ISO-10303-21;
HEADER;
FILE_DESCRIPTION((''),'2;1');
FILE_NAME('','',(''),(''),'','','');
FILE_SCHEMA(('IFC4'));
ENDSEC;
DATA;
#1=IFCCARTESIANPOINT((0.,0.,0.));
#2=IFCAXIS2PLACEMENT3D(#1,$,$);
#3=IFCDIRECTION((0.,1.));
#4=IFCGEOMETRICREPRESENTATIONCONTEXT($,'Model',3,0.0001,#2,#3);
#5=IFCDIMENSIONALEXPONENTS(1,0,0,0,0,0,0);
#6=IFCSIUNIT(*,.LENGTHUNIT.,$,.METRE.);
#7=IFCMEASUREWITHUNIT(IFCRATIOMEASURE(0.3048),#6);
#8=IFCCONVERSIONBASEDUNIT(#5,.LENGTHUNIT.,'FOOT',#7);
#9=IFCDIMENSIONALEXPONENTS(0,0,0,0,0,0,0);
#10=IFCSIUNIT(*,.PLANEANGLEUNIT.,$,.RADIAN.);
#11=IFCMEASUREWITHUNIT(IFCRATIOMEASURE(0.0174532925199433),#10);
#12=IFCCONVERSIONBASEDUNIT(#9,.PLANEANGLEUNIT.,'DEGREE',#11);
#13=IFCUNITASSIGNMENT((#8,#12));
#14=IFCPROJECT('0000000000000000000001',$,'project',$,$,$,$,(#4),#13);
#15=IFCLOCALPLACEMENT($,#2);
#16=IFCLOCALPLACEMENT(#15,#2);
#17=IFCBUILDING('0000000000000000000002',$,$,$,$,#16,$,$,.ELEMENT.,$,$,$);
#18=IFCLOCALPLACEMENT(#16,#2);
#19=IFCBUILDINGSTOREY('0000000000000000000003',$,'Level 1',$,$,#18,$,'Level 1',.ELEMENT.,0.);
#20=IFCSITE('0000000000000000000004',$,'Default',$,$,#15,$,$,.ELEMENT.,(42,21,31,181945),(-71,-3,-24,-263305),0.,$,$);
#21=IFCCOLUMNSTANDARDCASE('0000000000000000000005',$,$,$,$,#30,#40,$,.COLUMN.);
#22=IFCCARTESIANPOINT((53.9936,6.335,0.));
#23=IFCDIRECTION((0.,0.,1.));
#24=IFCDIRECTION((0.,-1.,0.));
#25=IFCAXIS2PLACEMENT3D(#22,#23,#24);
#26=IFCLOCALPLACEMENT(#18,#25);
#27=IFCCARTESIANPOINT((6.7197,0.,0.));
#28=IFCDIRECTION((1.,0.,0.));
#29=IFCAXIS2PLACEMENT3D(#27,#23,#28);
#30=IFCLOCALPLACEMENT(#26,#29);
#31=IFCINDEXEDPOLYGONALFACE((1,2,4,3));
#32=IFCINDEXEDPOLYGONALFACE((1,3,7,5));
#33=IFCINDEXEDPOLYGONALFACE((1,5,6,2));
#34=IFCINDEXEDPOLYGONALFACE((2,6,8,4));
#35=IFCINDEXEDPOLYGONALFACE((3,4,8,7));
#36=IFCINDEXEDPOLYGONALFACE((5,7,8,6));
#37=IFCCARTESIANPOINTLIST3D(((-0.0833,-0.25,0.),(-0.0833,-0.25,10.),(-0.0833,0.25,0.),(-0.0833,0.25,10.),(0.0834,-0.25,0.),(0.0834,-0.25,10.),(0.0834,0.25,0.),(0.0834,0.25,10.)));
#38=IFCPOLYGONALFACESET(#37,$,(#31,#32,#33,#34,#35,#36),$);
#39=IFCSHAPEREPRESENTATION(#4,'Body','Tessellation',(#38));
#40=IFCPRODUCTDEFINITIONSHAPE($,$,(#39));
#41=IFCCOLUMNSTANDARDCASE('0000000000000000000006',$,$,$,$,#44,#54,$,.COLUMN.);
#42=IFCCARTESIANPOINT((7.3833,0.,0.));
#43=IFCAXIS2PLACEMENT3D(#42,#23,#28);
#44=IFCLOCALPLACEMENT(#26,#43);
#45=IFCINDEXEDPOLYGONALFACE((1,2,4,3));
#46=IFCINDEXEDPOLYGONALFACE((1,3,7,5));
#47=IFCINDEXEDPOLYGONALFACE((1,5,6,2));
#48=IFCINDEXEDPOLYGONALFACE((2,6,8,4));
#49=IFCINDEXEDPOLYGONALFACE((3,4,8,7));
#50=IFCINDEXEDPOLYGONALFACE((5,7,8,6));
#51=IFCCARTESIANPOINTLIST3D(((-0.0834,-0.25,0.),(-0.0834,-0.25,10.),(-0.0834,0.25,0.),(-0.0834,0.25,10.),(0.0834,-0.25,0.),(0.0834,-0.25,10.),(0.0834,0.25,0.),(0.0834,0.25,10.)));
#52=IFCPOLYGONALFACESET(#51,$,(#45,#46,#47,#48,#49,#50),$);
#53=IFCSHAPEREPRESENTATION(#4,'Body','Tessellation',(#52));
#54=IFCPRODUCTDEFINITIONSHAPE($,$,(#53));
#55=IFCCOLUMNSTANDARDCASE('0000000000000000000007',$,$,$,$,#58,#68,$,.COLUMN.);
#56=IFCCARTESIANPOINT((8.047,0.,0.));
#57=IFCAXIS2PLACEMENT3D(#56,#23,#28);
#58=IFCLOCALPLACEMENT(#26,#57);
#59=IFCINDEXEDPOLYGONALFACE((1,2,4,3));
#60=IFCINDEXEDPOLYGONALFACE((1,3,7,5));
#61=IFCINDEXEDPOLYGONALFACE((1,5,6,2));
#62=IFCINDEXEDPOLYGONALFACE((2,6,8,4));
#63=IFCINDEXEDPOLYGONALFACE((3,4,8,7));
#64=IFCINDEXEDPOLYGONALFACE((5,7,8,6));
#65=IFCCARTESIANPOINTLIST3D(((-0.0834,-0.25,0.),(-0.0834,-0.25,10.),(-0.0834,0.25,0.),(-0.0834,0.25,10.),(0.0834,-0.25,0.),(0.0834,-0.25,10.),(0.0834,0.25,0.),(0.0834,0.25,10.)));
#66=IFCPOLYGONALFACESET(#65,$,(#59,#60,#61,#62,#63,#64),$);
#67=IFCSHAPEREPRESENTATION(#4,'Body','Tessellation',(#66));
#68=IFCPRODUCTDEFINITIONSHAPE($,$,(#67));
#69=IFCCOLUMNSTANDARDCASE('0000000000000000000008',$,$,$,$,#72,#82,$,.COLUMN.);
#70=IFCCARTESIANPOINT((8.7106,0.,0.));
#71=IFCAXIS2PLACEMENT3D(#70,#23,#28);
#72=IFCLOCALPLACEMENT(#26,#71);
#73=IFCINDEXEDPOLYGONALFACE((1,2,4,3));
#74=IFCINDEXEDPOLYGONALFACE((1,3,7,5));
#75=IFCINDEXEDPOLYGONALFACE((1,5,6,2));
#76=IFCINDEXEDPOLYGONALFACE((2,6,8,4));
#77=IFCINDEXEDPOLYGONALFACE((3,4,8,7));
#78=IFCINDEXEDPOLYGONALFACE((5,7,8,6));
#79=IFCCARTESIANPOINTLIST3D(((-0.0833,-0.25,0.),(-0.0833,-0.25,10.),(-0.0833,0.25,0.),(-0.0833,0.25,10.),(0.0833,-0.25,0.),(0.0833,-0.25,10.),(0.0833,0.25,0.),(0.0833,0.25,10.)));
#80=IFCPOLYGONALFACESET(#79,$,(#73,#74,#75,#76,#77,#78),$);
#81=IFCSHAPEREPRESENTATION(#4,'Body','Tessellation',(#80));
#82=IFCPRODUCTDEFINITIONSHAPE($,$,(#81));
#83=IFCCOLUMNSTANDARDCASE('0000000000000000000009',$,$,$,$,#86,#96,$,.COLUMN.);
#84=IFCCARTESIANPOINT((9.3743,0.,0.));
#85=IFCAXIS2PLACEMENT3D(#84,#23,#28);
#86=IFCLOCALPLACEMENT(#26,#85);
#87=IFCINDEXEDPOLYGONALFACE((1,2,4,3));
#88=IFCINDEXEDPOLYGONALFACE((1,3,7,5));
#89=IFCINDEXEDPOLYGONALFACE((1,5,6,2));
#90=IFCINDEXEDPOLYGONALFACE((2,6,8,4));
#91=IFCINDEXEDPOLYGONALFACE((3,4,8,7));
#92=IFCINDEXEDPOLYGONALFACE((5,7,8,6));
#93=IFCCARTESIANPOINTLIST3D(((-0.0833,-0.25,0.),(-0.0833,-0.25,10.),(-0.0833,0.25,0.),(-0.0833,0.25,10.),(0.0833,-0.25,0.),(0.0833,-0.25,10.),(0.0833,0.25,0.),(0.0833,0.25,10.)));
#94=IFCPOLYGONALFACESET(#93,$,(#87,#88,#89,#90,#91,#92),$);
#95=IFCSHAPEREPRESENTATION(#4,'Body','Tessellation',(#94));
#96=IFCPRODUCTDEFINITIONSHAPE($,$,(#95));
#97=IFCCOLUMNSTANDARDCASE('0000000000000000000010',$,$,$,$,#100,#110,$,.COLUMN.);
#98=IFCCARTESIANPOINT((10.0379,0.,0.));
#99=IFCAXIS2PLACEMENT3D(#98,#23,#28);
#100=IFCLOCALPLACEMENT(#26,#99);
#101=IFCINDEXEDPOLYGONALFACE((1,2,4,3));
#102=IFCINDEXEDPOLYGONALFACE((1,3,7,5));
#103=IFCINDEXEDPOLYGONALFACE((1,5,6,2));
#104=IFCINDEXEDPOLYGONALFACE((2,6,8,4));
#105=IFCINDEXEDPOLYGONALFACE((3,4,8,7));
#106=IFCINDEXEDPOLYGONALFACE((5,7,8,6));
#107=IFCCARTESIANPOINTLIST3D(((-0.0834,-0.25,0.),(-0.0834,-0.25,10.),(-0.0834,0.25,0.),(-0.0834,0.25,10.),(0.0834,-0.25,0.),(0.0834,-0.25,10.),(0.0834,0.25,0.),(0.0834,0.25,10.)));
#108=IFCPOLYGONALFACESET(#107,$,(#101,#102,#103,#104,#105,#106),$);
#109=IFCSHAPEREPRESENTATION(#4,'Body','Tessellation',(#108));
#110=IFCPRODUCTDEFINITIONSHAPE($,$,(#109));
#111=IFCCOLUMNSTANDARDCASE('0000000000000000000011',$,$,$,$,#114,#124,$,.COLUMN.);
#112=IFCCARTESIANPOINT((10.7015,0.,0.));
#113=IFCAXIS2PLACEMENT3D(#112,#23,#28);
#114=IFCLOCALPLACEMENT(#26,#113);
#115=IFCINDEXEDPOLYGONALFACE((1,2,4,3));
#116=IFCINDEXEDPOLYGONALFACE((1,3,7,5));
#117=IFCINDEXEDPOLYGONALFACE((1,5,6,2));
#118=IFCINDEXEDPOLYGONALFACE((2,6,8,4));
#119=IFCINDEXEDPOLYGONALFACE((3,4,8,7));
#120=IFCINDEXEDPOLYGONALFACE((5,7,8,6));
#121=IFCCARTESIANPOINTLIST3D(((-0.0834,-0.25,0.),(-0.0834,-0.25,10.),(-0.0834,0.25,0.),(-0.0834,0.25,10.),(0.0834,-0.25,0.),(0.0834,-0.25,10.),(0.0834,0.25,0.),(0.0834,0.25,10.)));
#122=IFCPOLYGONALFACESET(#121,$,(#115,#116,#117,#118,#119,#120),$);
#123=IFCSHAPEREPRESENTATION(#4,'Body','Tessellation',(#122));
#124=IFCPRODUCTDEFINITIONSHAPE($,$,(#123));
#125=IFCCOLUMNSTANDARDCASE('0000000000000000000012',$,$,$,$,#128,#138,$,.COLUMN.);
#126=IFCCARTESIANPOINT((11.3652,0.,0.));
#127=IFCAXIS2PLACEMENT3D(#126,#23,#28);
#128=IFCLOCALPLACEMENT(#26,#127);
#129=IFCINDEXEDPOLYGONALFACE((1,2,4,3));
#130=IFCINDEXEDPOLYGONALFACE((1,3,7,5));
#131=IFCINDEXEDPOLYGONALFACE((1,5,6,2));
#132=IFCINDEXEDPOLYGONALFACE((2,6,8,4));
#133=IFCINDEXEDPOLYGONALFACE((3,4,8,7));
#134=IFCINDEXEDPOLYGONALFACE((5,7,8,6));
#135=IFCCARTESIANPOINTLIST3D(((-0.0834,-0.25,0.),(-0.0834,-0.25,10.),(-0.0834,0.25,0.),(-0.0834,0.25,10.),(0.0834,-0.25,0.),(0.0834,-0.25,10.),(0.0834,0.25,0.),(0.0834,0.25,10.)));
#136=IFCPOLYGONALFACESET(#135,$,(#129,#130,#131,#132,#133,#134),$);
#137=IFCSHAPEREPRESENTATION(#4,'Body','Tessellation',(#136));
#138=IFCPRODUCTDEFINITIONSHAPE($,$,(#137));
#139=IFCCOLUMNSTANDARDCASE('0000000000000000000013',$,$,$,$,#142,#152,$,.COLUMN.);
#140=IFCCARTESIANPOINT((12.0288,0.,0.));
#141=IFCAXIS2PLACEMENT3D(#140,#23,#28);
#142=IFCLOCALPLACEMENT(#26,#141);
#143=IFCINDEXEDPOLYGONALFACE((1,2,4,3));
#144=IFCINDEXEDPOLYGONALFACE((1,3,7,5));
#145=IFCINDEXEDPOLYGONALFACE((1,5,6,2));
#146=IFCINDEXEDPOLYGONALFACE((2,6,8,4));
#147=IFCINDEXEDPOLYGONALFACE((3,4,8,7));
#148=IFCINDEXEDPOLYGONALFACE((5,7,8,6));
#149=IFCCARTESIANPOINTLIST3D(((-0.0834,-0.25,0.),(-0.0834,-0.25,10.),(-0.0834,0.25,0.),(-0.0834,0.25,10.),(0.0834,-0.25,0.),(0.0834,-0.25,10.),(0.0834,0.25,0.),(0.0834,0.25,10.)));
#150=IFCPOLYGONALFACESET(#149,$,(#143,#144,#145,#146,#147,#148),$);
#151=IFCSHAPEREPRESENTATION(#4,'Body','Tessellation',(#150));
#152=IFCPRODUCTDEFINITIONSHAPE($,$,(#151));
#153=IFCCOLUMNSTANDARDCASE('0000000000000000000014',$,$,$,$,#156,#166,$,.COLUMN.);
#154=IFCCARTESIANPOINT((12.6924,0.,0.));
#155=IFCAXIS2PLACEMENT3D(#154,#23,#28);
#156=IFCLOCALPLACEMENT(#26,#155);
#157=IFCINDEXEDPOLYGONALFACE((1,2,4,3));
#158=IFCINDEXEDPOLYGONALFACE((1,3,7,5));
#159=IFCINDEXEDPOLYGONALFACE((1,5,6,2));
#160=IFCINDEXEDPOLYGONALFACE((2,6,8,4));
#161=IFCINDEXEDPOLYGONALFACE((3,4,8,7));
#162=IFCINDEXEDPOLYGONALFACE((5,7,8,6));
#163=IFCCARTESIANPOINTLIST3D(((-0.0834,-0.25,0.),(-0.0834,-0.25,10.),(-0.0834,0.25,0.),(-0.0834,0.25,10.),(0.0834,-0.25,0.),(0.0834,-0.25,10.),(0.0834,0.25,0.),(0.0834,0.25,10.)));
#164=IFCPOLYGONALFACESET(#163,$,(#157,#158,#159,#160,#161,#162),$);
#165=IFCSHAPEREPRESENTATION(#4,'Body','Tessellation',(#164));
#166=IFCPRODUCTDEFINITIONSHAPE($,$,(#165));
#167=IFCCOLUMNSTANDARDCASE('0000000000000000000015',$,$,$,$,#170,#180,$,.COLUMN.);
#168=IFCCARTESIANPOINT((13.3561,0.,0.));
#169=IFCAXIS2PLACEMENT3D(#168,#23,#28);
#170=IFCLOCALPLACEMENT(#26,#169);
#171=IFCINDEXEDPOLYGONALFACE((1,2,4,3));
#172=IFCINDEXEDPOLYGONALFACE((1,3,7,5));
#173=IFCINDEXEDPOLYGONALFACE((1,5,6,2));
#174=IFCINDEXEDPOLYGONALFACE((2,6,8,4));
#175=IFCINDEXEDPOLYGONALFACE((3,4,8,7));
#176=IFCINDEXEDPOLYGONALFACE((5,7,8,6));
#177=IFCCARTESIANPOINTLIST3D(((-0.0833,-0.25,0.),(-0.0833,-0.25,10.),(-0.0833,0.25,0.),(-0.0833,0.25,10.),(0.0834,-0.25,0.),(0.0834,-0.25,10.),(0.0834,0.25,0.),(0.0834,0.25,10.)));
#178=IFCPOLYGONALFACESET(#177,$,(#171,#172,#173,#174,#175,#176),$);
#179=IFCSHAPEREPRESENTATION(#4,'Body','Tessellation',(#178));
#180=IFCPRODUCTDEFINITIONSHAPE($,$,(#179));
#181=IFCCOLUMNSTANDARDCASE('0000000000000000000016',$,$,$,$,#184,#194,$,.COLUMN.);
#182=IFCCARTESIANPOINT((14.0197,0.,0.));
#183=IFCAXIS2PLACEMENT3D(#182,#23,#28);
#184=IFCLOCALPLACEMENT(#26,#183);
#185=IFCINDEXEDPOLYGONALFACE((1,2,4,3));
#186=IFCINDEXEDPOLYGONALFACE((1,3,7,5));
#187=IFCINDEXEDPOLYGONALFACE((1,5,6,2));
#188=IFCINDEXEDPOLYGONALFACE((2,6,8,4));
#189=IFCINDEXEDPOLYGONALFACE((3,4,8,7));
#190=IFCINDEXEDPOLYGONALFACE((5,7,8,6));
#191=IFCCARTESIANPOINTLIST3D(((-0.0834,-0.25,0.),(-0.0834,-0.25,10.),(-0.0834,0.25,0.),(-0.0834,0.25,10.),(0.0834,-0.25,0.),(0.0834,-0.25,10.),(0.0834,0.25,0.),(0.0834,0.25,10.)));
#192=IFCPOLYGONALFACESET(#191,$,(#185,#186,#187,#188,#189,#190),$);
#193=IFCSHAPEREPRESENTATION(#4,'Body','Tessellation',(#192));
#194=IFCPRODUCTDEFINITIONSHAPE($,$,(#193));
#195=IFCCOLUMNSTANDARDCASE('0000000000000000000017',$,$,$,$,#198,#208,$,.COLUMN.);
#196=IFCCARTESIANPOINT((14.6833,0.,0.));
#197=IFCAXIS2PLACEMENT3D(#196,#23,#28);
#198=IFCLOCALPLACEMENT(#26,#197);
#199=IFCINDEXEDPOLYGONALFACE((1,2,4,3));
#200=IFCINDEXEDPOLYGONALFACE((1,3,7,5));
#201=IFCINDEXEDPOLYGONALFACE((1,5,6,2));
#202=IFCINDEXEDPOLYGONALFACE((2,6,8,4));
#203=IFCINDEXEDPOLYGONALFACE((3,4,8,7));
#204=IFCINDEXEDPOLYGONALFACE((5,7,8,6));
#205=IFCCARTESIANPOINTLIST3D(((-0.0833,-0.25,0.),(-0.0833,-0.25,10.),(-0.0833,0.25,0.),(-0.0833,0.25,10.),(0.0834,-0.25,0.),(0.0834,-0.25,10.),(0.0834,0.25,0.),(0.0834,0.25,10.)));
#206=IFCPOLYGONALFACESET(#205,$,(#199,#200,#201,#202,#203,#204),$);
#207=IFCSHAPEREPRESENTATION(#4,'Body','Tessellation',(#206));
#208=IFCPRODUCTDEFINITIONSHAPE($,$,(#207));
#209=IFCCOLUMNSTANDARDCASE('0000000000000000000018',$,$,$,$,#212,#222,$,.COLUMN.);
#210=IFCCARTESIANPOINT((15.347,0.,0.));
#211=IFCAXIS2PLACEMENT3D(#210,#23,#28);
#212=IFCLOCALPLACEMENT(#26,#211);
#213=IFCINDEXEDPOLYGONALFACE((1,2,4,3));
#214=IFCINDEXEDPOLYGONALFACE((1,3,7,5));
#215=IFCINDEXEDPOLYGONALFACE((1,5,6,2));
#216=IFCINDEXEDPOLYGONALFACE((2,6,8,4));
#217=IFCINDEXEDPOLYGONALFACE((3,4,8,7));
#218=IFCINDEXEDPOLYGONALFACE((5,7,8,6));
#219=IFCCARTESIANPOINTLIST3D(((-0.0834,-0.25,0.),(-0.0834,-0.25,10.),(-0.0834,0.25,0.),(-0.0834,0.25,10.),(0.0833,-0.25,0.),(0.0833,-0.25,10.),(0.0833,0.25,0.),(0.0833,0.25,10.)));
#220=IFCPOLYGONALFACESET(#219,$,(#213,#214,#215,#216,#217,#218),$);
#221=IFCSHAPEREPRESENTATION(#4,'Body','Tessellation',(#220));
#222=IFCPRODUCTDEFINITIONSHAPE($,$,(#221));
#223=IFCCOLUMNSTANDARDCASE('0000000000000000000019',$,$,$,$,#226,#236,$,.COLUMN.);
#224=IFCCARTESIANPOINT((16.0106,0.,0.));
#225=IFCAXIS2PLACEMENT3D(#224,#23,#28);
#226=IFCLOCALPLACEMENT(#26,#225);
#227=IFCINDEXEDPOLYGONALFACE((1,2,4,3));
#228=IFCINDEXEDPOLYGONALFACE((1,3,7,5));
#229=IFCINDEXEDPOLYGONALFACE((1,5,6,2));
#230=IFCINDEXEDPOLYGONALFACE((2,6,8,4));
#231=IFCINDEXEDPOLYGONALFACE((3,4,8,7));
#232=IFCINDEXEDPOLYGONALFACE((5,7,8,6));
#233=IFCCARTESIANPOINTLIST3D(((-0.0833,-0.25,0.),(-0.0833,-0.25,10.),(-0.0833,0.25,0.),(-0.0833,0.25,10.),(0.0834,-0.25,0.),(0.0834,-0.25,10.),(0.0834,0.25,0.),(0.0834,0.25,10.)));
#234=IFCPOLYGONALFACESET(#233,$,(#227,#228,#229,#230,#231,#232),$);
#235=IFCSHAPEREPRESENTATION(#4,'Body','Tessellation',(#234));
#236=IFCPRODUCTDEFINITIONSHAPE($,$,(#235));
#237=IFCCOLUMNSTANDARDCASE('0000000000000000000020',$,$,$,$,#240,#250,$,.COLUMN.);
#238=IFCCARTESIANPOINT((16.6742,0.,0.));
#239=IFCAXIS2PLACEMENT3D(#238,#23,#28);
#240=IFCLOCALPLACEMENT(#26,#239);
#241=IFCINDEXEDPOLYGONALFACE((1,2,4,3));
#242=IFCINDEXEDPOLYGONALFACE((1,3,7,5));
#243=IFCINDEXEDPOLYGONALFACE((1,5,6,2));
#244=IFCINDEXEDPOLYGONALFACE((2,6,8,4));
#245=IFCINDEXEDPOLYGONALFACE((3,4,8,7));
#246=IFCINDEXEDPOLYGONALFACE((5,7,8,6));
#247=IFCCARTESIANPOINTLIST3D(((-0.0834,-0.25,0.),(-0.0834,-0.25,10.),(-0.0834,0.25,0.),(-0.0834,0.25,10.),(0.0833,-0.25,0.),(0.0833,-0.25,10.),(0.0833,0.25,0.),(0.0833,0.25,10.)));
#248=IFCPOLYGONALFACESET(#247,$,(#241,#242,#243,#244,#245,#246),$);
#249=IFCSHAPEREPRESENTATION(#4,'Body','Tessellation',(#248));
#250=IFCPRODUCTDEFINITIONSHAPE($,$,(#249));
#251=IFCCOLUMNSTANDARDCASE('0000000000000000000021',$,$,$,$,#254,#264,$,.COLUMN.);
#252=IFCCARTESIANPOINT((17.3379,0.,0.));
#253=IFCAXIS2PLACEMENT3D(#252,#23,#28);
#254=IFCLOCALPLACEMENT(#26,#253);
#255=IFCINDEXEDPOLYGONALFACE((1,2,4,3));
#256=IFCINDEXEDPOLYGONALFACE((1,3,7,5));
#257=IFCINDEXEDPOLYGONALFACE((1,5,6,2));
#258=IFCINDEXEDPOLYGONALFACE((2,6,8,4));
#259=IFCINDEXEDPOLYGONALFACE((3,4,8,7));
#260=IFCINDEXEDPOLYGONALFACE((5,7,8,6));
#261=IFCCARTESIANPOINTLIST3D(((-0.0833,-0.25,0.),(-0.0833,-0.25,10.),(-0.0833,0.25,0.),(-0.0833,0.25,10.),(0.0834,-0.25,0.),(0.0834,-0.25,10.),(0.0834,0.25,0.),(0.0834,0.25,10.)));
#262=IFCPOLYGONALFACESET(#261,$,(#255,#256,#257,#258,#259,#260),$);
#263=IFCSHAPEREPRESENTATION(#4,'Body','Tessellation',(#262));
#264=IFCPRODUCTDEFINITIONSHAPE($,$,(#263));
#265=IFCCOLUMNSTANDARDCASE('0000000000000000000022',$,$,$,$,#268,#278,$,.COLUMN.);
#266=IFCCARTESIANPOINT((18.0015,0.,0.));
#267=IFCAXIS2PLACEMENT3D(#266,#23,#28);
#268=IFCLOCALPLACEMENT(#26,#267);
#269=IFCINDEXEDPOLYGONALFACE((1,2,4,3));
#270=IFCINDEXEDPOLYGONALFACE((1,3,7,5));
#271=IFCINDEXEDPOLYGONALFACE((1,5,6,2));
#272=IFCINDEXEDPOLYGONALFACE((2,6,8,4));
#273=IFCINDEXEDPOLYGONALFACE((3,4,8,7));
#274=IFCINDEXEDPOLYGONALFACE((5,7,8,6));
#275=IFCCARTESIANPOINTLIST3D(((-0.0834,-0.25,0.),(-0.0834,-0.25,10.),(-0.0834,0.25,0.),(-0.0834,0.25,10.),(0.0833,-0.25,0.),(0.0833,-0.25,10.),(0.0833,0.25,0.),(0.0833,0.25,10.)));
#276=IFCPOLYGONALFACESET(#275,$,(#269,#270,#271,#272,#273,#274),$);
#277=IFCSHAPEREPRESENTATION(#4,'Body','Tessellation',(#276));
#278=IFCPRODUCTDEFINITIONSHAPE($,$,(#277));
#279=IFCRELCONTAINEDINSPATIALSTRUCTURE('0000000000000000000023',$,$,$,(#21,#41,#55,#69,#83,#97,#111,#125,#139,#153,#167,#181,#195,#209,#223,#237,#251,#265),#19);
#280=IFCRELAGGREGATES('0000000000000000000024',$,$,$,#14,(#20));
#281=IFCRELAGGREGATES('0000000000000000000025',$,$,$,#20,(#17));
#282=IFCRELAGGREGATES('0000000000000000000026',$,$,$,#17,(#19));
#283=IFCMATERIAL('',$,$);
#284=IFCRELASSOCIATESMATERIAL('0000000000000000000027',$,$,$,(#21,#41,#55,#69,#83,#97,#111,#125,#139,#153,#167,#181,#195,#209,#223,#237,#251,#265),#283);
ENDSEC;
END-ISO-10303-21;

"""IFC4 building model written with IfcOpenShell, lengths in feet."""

from ifc_helpers import new_model, entity, si_unit, converted_unit, direction, frame, origin, place, context, project, spatial, rectangle, extrude, material, element, save


model = new_model("IFC4")

# Units and contexts
model_context = context("Model", 3, precision=0.0001, world=origin(), true_north=direction((0.0, 1.0)))
ifc_project = project(units=[converted_unit("LENGTHUNIT", "FOOT", entity("IfcRatioMeasure", 0.3048), si_unit("LENGTHUNIT", "METRE"), dimensions=[1, 0, 0, 0, 0, 0, 0]), converted_unit("PLANEANGLEUNIT", "DEGREE", entity("IfcRatioMeasure", 0.0174532925199433), si_unit("PLANEANGLEUNIT", "RADIAN"), dimensions=[0, 0, 0, 0, 0, 0, 0])], contexts=[model_context])

# Site, building, storey
site_placement = place(None, origin())
site = spatial("IfcSite", under=ifc_project, at=site_placement, Name="Default", CompositionType="ELEMENT", RefLatitude=(42, 21, 31, 181945), RefLongitude=(-71, -3, -24, -263305), RefElevation=0.0)
building_placement = place(site_placement, origin())
building = spatial("IfcBuilding", under=site, at=building_placement, CompositionType="ELEMENT")
storey_placement = place(building_placement, origin())
storey = spatial("IfcBuildingStorey", under=building, at=storey_placement, Name="Level 1", LongName="Level 1", CompositionType="ELEMENT", Elevation=0.0)

# Columns
ifc_material_1 = material(Name="")
placement = place(storey_placement, frame((53.9936, 6.335, 0.0), z_axis=(0.0, 0.0, 1.0), x_axis=(0.0, -1.0, 0.0)))
for number, where, z_axis, x_axis in (
    (1, (6.7197, 0.0, 0.0), (0.0, 0.0, 1.0), (1.0, 0.0, 0.0)),
    (2, (7.3833, 0.0, 0.0), (0.0, 0.0, 1.0), (1.0, 0.0, 0.0)),
    (3, (8.047, 0.0, 0.0), (0.0, 0.0, 1.0), (1.0, 0.0, 0.0)),
    (4, (8.7106, 0.0, 0.0), (0.0, 0.0, 1.0), (1.0, 0.0, 0.0)),
    (5, (9.3743, 0.0, 0.0), (0.0, 0.0, 1.0), (1.0, 0.0, 0.0)),
    (6, (10.0379, 0.0, 0.0), (0.0, 0.0, 1.0), (1.0, 0.0, 0.0)),
    (7, (10.7015, 0.0, 0.0), (0.0, 0.0, 1.0), (1.0, 0.0, 0.0)),
    (8, (11.3652, 0.0, 0.0), (0.0, 0.0, 1.0), (1.0, 0.0, 0.0)),
    (9, (12.0288, 0.0, 0.0), (0.0, 0.0, 1.0), (1.0, 0.0, 0.0)),
    (10, (12.6924, 0.0, 0.0), (0.0, 0.0, 1.0), (1.0, 0.0, 0.0)),
    (11, (13.3561, 0.0, 0.0), (0.0, 0.0, 1.0), (1.0, 0.0, 0.0)),
    (12, (14.0197, 0.0, 0.0), (0.0, 0.0, 1.0), (1.0, 0.0, 0.0)),
    (13, (14.6833, 0.0, 0.0), (0.0, 0.0, 1.0), (1.0, 0.0, 0.0)),
    (14, (15.347, 0.0, 0.0), (0.0, 0.0, 1.0), (1.0, 0.0, 0.0)),
    (15, (16.0106, 0.0, 0.0), (0.0, 0.0, 1.0), (1.0, 0.0, 0.0)),
    (16, (16.6742, 0.0, 0.0), (0.0, 0.0, 1.0), (1.0, 0.0, 0.0)),
    (17, (17.3379, 0.0, 0.0), (0.0, 0.0, 1.0), (1.0, 0.0, 0.0)),
    (18, (18.0015, 0.0, 0.0), (0.0, 0.0, 1.0), (1.0, 0.0, 0.0)),
):
    element("IfcColumnStandardCase", number, at=place(placement, frame(where, z_axis=z_axis, x_axis=x_axis)), inside=storey, material=ifc_material_1, PredefinedType="COLUMN", context=model_context, shape_type="SweptSolid", body=[
        extrude(rectangle(XDim=0.1667, YDim=0.5), origin(), (0.0, 0.0, 1.0), 10.0),
    ])

save(model, "model.ifc")
